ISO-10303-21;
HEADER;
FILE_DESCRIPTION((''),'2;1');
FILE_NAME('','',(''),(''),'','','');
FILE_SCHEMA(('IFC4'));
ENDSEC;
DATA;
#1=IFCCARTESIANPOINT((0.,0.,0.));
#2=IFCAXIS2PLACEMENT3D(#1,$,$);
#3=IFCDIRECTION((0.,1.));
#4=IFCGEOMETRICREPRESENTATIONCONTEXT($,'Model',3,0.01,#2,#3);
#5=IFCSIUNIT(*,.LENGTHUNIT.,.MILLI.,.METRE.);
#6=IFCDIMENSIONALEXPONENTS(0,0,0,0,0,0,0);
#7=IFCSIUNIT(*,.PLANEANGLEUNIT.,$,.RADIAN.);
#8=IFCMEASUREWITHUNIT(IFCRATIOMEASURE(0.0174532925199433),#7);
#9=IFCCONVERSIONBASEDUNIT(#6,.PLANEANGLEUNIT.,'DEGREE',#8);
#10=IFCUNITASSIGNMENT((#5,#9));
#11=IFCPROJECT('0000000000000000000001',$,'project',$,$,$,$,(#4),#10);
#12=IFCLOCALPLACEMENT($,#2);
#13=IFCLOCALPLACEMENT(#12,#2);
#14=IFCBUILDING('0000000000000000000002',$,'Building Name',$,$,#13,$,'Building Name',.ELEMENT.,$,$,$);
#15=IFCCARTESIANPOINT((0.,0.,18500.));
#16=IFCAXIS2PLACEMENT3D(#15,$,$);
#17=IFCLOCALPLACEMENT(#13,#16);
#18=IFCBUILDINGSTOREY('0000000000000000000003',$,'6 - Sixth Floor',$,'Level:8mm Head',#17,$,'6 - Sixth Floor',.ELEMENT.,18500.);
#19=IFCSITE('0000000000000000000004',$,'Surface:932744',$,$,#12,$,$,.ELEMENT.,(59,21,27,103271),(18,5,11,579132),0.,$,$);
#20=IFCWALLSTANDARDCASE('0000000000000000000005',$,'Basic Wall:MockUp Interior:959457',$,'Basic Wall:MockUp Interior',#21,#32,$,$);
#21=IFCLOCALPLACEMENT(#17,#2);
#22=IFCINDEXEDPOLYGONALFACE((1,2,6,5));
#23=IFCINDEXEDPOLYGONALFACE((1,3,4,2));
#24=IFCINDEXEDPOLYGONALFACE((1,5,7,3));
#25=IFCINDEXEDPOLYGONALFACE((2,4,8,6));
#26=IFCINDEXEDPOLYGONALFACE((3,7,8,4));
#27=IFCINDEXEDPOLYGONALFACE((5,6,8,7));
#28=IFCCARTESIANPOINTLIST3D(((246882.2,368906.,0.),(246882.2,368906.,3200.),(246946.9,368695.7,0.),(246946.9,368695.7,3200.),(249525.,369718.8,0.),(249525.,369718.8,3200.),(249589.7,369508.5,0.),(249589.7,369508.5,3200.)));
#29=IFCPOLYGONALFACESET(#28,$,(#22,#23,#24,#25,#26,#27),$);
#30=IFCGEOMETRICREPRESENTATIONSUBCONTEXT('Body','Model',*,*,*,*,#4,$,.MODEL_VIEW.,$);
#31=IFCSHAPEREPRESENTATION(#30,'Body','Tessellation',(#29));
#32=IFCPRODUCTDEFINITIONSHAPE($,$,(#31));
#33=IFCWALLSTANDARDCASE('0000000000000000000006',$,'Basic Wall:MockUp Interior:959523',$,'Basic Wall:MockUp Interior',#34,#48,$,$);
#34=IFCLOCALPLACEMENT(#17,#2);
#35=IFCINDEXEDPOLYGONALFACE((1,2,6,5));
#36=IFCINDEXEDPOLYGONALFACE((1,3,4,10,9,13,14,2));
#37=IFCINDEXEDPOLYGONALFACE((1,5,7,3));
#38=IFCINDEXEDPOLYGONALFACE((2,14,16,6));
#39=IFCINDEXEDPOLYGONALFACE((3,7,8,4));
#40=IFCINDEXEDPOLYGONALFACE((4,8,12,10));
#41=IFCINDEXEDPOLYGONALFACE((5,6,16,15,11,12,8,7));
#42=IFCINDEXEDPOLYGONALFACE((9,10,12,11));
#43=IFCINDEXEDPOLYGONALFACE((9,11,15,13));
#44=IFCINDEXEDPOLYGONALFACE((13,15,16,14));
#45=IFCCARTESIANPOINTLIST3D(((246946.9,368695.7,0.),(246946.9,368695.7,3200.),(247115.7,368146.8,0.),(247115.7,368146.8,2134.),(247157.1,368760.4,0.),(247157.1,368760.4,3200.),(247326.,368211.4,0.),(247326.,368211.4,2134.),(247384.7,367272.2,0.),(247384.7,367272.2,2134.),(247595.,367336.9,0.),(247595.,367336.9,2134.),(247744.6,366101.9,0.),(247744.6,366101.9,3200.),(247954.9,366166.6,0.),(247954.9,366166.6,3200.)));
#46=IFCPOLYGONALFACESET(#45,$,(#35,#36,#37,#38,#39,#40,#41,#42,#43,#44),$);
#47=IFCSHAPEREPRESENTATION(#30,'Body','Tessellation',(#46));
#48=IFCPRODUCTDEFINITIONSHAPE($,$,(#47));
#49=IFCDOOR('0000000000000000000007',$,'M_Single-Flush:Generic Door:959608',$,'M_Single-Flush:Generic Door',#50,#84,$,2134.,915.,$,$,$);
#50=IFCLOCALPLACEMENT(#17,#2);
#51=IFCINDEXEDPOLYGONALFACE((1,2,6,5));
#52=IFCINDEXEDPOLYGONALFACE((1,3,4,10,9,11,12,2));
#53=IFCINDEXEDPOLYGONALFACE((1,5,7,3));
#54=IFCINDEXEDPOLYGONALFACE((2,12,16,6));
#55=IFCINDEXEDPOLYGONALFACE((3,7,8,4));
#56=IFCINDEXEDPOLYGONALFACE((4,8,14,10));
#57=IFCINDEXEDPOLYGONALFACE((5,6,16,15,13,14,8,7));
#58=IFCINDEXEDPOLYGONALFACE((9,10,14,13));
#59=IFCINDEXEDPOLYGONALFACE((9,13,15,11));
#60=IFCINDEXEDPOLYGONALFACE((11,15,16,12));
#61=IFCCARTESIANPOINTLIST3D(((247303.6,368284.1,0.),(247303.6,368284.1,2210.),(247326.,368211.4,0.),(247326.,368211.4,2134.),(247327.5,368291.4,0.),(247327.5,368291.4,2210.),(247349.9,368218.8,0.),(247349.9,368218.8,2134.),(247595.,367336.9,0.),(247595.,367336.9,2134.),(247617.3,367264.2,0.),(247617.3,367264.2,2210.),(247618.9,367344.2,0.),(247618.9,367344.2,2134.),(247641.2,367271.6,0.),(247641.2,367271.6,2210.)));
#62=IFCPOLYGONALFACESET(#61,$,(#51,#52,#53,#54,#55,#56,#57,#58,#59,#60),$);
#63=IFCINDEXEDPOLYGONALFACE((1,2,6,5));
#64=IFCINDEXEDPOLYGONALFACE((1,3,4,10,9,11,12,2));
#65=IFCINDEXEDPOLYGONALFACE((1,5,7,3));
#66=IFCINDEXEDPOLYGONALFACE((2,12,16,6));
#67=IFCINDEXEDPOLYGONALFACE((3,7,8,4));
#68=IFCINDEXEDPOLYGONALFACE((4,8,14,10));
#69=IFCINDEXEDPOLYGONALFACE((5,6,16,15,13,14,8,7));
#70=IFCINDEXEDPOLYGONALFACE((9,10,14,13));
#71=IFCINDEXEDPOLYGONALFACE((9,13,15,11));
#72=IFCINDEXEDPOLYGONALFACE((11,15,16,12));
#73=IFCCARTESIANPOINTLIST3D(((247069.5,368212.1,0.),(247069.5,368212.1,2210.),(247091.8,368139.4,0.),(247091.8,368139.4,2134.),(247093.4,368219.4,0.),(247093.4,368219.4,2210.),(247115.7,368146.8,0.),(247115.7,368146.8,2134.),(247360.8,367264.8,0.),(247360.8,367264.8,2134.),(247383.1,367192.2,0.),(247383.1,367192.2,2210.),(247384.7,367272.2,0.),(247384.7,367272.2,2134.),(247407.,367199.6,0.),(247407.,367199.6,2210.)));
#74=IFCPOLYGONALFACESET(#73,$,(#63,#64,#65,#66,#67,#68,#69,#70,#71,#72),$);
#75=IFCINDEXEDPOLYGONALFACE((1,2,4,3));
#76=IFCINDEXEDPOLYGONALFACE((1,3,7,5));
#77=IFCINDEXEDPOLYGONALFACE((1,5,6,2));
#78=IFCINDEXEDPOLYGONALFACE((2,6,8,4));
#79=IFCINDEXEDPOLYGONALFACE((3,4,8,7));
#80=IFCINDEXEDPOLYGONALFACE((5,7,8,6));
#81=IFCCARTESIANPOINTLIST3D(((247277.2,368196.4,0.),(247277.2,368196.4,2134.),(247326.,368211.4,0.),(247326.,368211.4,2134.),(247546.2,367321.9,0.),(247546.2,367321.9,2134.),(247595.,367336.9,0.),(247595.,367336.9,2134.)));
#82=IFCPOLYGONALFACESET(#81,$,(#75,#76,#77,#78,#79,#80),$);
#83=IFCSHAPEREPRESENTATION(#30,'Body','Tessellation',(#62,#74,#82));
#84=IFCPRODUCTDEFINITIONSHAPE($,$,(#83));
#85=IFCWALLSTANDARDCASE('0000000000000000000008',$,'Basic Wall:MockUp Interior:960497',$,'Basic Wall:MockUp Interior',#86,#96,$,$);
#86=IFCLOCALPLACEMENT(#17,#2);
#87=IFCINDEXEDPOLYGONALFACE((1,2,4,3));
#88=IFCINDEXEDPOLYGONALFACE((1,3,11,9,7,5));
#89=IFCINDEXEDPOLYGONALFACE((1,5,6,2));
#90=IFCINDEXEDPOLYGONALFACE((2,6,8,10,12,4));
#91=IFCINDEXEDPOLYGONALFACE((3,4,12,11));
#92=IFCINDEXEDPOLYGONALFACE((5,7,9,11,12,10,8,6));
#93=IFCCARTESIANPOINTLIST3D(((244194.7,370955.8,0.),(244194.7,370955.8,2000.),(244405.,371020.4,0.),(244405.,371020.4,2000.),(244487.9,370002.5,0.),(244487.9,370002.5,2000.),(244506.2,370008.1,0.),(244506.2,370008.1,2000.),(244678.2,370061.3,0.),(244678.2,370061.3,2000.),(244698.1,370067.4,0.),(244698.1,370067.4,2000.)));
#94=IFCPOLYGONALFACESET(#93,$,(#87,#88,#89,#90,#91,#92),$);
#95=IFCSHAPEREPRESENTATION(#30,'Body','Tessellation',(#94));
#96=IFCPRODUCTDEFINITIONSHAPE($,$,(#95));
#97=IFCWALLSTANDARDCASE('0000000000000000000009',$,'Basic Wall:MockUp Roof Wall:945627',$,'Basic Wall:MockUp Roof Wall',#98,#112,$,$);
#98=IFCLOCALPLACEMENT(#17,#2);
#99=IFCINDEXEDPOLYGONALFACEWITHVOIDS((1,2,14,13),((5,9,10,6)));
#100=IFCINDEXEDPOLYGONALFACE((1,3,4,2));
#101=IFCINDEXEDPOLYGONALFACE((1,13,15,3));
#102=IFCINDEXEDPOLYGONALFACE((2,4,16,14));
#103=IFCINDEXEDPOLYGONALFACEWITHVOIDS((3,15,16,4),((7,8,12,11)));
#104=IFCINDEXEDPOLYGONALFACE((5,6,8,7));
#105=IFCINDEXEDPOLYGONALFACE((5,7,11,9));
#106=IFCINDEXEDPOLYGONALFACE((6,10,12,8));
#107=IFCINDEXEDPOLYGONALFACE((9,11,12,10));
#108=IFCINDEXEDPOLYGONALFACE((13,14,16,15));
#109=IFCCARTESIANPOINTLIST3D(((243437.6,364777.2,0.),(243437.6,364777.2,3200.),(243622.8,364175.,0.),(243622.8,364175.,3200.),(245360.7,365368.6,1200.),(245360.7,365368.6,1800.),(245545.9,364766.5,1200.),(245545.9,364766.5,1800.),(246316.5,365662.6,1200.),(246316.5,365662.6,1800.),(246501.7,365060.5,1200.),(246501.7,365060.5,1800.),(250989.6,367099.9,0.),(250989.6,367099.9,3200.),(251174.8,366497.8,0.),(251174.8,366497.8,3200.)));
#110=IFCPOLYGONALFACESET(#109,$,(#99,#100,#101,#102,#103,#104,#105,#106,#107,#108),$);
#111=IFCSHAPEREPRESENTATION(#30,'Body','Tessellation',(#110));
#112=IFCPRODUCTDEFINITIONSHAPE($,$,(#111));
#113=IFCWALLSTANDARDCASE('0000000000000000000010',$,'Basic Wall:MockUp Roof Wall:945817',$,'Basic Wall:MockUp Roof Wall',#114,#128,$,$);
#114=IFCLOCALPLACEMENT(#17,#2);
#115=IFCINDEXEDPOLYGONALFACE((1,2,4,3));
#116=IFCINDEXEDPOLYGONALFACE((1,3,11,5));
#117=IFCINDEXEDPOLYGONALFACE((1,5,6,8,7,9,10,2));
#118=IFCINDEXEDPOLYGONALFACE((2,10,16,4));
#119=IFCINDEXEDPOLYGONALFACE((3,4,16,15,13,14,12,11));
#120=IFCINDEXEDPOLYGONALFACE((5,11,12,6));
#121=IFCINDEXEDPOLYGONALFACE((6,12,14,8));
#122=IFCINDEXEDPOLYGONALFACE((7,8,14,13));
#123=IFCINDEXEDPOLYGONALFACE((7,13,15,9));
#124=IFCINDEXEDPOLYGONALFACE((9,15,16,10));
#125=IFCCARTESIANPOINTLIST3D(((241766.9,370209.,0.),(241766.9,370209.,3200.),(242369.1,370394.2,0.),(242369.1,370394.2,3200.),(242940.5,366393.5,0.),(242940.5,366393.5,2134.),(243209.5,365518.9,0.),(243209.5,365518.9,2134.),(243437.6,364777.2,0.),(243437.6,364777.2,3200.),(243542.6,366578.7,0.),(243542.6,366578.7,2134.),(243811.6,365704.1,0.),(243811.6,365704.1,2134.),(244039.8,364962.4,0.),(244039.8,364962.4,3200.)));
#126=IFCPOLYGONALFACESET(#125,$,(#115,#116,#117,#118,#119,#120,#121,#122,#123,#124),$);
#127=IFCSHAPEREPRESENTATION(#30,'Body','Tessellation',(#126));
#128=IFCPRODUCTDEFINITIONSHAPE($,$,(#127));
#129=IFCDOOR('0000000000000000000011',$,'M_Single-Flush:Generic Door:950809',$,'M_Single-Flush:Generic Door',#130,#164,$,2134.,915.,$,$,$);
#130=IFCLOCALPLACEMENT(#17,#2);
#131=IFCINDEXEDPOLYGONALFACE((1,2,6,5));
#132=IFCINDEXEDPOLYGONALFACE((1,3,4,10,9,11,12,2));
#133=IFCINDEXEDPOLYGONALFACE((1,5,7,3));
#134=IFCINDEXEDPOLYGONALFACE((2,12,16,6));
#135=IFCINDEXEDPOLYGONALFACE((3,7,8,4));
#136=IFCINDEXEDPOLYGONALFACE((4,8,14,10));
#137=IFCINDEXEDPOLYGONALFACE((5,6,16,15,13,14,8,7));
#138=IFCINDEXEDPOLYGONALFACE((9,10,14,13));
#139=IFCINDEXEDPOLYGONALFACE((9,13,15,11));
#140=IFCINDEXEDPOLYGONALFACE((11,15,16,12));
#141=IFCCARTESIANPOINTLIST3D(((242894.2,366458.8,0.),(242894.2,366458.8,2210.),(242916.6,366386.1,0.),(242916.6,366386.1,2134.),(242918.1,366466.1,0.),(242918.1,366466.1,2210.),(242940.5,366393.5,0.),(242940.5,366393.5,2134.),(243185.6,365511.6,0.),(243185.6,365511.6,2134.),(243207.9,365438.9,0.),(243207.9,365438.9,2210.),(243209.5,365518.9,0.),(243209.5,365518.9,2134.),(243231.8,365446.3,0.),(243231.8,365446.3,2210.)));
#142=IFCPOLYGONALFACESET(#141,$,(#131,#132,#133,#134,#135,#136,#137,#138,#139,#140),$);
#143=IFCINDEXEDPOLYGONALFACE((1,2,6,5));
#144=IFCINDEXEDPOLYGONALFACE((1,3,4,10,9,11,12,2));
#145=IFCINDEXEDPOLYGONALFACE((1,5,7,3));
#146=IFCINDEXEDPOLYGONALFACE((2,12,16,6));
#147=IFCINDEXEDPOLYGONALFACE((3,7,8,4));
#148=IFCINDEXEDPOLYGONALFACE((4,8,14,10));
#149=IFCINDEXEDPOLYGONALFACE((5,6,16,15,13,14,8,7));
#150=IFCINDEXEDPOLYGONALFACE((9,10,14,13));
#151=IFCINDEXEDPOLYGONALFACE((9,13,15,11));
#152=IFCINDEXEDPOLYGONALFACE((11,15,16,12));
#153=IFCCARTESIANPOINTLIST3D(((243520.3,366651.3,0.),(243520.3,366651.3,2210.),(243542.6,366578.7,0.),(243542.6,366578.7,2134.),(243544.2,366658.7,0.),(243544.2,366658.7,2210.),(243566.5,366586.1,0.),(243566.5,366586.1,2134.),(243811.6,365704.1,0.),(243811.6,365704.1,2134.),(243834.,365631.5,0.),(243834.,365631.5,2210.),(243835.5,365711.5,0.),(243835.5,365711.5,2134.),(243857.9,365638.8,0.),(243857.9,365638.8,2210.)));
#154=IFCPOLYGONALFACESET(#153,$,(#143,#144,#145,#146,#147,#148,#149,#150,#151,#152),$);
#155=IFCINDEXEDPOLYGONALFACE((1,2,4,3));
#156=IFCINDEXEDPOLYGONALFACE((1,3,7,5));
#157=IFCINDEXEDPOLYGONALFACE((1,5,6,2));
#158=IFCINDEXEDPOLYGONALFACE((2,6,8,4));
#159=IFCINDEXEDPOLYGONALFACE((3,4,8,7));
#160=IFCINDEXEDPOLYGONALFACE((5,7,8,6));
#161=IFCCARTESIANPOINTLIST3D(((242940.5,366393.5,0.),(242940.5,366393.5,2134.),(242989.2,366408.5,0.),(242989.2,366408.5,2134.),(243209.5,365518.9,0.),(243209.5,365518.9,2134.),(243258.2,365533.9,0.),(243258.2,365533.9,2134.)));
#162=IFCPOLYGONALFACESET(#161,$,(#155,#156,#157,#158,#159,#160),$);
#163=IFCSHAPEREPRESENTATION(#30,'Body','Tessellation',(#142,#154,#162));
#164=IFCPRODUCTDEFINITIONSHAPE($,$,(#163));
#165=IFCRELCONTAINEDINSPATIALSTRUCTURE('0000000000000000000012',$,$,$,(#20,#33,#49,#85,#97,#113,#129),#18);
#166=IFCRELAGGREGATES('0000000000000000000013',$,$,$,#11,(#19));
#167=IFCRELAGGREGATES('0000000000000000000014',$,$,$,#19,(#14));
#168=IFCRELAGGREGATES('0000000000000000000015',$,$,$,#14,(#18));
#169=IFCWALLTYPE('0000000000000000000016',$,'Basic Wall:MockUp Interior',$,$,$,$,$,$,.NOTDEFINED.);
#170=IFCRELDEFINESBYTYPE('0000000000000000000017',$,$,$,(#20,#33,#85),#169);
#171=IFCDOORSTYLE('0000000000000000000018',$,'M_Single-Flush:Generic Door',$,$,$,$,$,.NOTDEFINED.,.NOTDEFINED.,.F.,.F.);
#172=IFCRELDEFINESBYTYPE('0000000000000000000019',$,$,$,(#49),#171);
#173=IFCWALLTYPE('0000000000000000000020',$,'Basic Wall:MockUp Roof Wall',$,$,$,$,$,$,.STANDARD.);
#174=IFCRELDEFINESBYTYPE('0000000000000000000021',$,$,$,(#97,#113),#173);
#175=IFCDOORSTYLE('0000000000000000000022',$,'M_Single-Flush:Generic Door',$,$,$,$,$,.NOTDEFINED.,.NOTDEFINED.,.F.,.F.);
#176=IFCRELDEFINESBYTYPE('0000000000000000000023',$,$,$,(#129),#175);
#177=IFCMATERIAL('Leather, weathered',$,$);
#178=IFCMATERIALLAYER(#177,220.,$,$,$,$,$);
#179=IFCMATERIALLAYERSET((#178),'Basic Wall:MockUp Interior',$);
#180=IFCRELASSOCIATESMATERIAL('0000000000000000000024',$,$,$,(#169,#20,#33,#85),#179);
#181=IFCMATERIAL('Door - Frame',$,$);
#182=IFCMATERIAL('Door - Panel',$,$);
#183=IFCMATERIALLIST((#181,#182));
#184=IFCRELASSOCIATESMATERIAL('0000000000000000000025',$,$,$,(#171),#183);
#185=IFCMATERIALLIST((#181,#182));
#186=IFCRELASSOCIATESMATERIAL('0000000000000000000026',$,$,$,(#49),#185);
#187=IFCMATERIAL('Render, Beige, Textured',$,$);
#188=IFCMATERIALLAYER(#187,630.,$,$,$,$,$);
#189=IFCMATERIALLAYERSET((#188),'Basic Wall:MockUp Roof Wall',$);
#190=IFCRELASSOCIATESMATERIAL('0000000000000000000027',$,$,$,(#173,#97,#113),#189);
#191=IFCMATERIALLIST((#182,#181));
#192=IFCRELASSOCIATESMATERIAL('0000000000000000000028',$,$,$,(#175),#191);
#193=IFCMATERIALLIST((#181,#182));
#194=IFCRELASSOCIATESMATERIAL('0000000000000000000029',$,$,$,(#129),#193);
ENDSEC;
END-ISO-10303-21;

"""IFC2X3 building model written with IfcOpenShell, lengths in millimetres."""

from ifc_helpers import new_model, entity, si_unit, converted_unit, direction, frame, frame_2d, origin, place, context, subcontext, project, spatial, polyline, rectangle, outline, extrude, source, transform, mapped, material, material_list, layer, layer_set, layer_usage, type_object, type_shapes, element, fill, save


model = new_model("IFC2X3")

# Units and contexts
model_context = context("Model", 3, precision=0.01, world=origin(), true_north=direction((0.0, 1.0)))
body_context = subcontext(model_context, "Body", "Model", "MODEL_VIEW")
ifc_project = project(units=[si_unit("LENGTHUNIT", "METRE", prefix="MILLI"), converted_unit("PLANEANGLEUNIT", "DEGREE", entity("IfcRatioMeasure", 0.0174532925199433), si_unit("PLANEANGLEUNIT", "RADIAN"), dimensions=[0, 0, 0, 0, 0, 0, 0])], contexts=[model_context])

# Site, building, storey
site_placement = place(None, origin())
site = spatial("IfcSite", under=ifc_project, at=site_placement, Name="Surface:932744", CompositionType="ELEMENT", RefLatitude=(59, 21, 27, 103271), RefLongitude=(18, 5, 11, 579132), RefElevation=0.0)
building_placement = place(site_placement, origin())
building = spatial("IfcBuilding", under=site, at=building_placement, Name="Building Name", LongName="Building Name", CompositionType="ELEMENT")
storey_placement = place(building_placement, frame((0.0, 0.0, 18500.0)))
storey = spatial("IfcBuildingStorey", under=building, at=storey_placement, Name="6 - Sixth Floor", ObjectType="Level:8mm Head", LongName="6 - Sixth Floor", CompositionType="ELEMENT", Elevation=18500.0)

# Wall
ifc_material_1 = material(Name="Leather, weathered")
ifc_layer_1 = layer(ifc_material_1, 220.0)
ifc_layer_set_1 = layer_set([ifc_layer_1], Name="Basic Wall:MockUp Interior")
ifc_layer_usage_1 = layer_usage(ifc_layer_set_1, "AXIS2", "NEGATIVE", 110.0)
wall_type_1 = type_object("IfcWallType", Name="Basic Wall:MockUp Interior", PredefinedType="NOTDEFINED", material=ifc_layer_set_1)
wall_1_placement = place(storey_placement, frame((249557.4, 369613.6, 0.0), z_axis=(0.0, 0.0, 1.0), x_axis=(-0.955818, -0.293958, 0.0)))
element("IfcWallStandardCase", 1, at=wall_1_placement, inside=storey, type_object=wall_type_1, material=ifc_layer_usage_1, Name="Basic Wall:MockUp Interior:959457", ObjectType="Basic Wall:MockUp Interior", context=body_context, shape_type="SweptSolid", body=[
    extrude(rectangle(XDim=2765.0, YDim=220.0, at=frame_2d((1382.5, 0.0), x_axis=(-1.0, 0.0))), origin(), (0.0, 0.0, 1.0), 3200.0),
])

# Wall, opening, door
ifc_layer_usage_2 = layer_usage(ifc_layer_set_1, "AXIS2", "NEGATIVE", 110.0)
wall_2_placement = place(storey_placement, frame((247052.0, 368728.0, 0.0), z_axis=(0.0, 0.0, 1.0), x_axis=(0.29398, -0.955811, 0.0)))
wall_2 = element("IfcWallStandardCase", 2, at=wall_2_placement, inside=storey, type_object=wall_type_1, material=ifc_layer_usage_2, Name="Basic Wall:MockUp Interior:959523", ObjectType="Basic Wall:MockUp Interior", context=body_context, shape_type="SweptSolid", body=[
    extrude(rectangle(XDim=2713.7, YDim=220.0, at=frame_2d((1356.9, 0.0), x_axis=(-1.0, 0.0))), origin(), (0.0, 0.0, 1.0), 3200.0),
])
opening_1_placement = place(wall_2_placement, frame((574.3, -110.0, 0.0)))
opening_1 = element("IfcOpeningElement", 3, at=opening_1_placement, cuts=wall_2, ObjectType="Opening", context=body_context, shape_type="SweptSolid", body=[
    extrude(rectangle(XDim=915.0, YDim=2134.0, at=frame_2d((1067.0, 457.5), x_axis=(0.0, 1.0))), frame((0.0, 0.0, 0.0), z_axis=(0.0, 1.0, 0.0), x_axis=(0.0, 0.0, 1.0)), (0.0, 0.0, 1.0), 220.0),
])
ifc_material_2 = material(Name="Door - Frame")
ifc_material_3 = material(Name="Door - Panel")
ifc_material_list_1 = material_list([ifc_material_2, ifc_material_3])
ifc_material_list_2 = material_list([ifc_material_2, ifc_material_3])
door_style_1 = type_object("IfcDoorStyle", Name="M_Single-Flush:Generic Door", ConstructionType="NOTDEFINED", OperationType="NOTDEFINED", ParameterTakesPrecedence=False, Sizeable=False, material=ifc_material_list_2)
shared_shape_1 = source(origin(), body_context, "Body", "SweptSolid", [
    extrude(outline(polyline([(-533.5, -1124.0), (533.5, -1124.0), (533.5, 1086.0), (457.5, 1086.0), (457.5, -1048.0), (-457.5, -1048.0), (-457.5, 1086.0), (-533.5, 1086.0), (-533.5, -1124.0)])), frame((457.5, 220.0, 1086.0), z_axis=(0.0, 1.0, 0.0), x_axis=(1.0, 0.0, 0.0)), (0.0, 0.0, 1.0), 25.0),
    extrude(outline(polyline([(-1124.0, -533.5), (1086.0, -533.5), (1086.0, -457.5), (-1048.0, -457.5), (-1048.0, 457.5), (1086.0, 457.5), (1086.0, 533.5), (-1124.0, 533.5), (-1124.0, -533.5)])), frame((457.5, -25.0, 1086.0), z_axis=(0.0, 1.0, 0.0), x_axis=(0.0, 0.0, -1.0)), (0.0, 0.0, 1.0), 25.0),
    extrude(rectangle(XDim=51.0, YDim=915.0, at=frame_2d((0.0, 0.0), x_axis=(1.0, 0.0))), frame((457.5, 194.5, 0.0), z_axis=(0.0, 0.0, 1.0), x_axis=(0.0, 1.0, 0.0)), (0.0, 0.0, 1.0), 2134.0),
])
type_shapes(door_style_1, [shared_shape_1])
door_1_placement = place(opening_1_placement, origin())
door_1 = element("IfcDoor", 4, at=door_1_placement, inside=storey, type_object=door_style_1, material=ifc_material_list_1, Name="M_Single-Flush:Generic Door:959608", ObjectType="M_Single-Flush:Generic Door", OverallHeight=2134.0, OverallWidth=915.0, context=body_context, shape_type="MappedRepresentation", body=[
    mapped(shared_shape_1, transform((0.0, 0.0, 0.0), scale=1.0)),
])
fill(opening_1, door_1)

# Wall
ifc_layer_usage_3 = layer_usage(ifc_layer_set_1, "AXIS2", "NEGATIVE", 110.0)
wall_3_placement = place(storey_placement, frame((244593.1, 370034.8, 0.0), z_axis=(0.0, 0.0, 1.0), x_axis=(-0.29398, 0.955811, 0.0)))
element("IfcWallStandardCase", 5, at=wall_3_placement, inside=storey, type_object=wall_type_1, material=ifc_layer_usage_3, Name="Basic Wall:MockUp Interior:960497", ObjectType="Basic Wall:MockUp Interior", context=body_context, shape_type="SweptSolid", body=[
    extrude(outline(polyline([(997.3, -110.0), (997.3, 110.0), (0.0, 110.0), (0.0, 90.9), (0.2, -89.1), (0.3, -110.0), (997.3, -110.0)])), origin(), (0.0, 0.0, 1.0), 2000.0),
])

# Wall, opening
ifc_material_4 = material(Name="Render, Beige, Textured")
ifc_layer_2 = layer(ifc_material_4, 630.0)
ifc_layer_set_2 = layer_set([ifc_layer_2], Name="Basic Wall:MockUp Roof Wall")
ifc_layer_usage_4 = layer_usage(ifc_layer_set_2, "AXIS2", "NEGATIVE", 315.0)
wall_type_2 = type_object("IfcWallType", Name="Basic Wall:MockUp Roof Wall", PredefinedType="STANDARD", material=ifc_layer_set_2)
wall_4_placement = place(storey_placement, frame((251082.2, 366798.9, 0.0), z_axis=(0.0, 0.0, 1.0), x_axis=(-0.955811, -0.29398, 0.0)))
wall_4 = element("IfcWallStandardCase", 6, at=wall_4_placement, inside=storey, type_object=wall_type_2, material=ifc_layer_usage_4, Name="Basic Wall:MockUp Roof Wall:945627", ObjectType="Basic Wall:MockUp Roof Wall", context=body_context, shape_type="SweptSolid", body=[
    extrude(rectangle(XDim=7901.1, YDim=630.0, at=frame_2d((3950.6, 0.0), x_axis=(-1.0, 0.0))), origin(), (0.0, 0.0, 1.0), 3200.0),
])
opening_2_placement = place(wall_4_placement, frame((5889.2, 315.0, 1200.0)))
element("IfcOpeningElement", 7, at=opening_2_placement, cuts=wall_4, ObjectType="Opening", context=body_context, shape_type="SweptSolid", body=[
    extrude(rectangle(XDim=600.0, YDim=1000.0, at=frame_2d((300.0, 500.0), x_axis=(1.0, 0.0))), frame((0.0, 0.0, 0.0), z_axis=(0.0, -1.0, 0.0), x_axis=(0.0, 0.0, 1.0)), (0.0, 0.0, 1.0), 630.0),
])

# Wall, opening, door
ifc_layer_usage_5 = layer_usage(ifc_layer_set_2, "AXIS2", "NEGATIVE", 315.0)
wall_5_placement = place(storey_placement, frame((242068.0, 370301.6, 0.0), z_axis=(0.0, 0.0, 1.0), x_axis=(0.29398, -0.955811, 0.0)))
wall_5 = element("IfcWallStandardCase", 8, at=wall_5_placement, inside=storey, type_object=wall_type_2, material=ifc_layer_usage_5, Name="Basic Wall:MockUp Roof Wall:945817", ObjectType="Basic Wall:MockUp Roof Wall", context=body_context, shape_type="SweptSolid", body=[
    extrude(rectangle(XDim=5683.0, YDim=630.0, at=frame_2d((2841.5, 0.0), x_axis=(-1.0, 0.0))), origin(), (0.0, 0.0, 1.0), 3200.0),
])
opening_3_placement = place(wall_5_placement, frame((4906.9, 315.0, 0.0)))
opening_3 = element("IfcOpeningElement", 9, at=opening_3_placement, cuts=wall_5, ObjectType="Opening", context=body_context, shape_type="SweptSolid", body=[
    extrude(rectangle(XDim=915.0, YDim=2134.0, at=frame_2d((1067.0, 457.5), x_axis=(0.0, -1.0))), frame((0.0, 0.0, 0.0), z_axis=(0.0, -1.0, 0.0), x_axis=(0.0, 0.0, 1.0)), (0.0, 0.0, 1.0), 630.0),
])
ifc_material_list_3 = material_list([ifc_material_2, ifc_material_3])
ifc_material_list_4 = material_list([ifc_material_3, ifc_material_2])
door_style_2 = type_object("IfcDoorStyle", Name="M_Single-Flush:Generic Door", ConstructionType="NOTDEFINED", OperationType="NOTDEFINED", ParameterTakesPrecedence=False, Sizeable=False, material=ifc_material_list_4)
shared_shape_2 = source(origin(), body_context, "Body", "SweptSolid", [
    extrude(outline(polyline([(-533.5, -1124.0), (533.5, -1124.0), (533.5, 1086.0), (457.5, 1086.0), (457.5, -1048.0), (-457.5, -1048.0), (-457.5, 1086.0), (-533.5, 1086.0), (-533.5, -1124.0)])), frame((457.5, 655.0, 1086.0), z_axis=(0.0, -1.0, 0.0), x_axis=(-1.0, 0.0, 0.0)), (0.0, 0.0, 1.0), 25.0),
    extrude(outline(polyline([(-1124.0, -533.5), (1086.0, -533.5), (1086.0, -457.5), (-1048.0, -457.5), (-1048.0, 457.5), (1086.0, 457.5), (1086.0, 533.5), (-1124.0, 533.5), (-1124.0, -533.5)])), frame((457.5, 0.0, 1086.0), z_axis=(0.0, -1.0, 0.0), x_axis=(0.0, 0.0, -1.0)), (0.0, 0.0, 1.0), 25.0),
    extrude(rectangle(XDim=915.0, YDim=51.0, at=frame_2d((0.0, 0.0), x_axis=(1.0, 0.0))), frame((457.5, 604.5, 0.0)), (0.0, 0.0, 1.0), 2134.0),
])
type_shapes(door_style_2, [shared_shape_2])
door_2_placement = place(opening_3_placement, frame((0.0, 0.0, 0.0), z_axis=(0.0, 0.0, 1.0), x_axis=(-1.0, 0.0, 0.0)))
door_2 = element("IfcDoor", 10, at=door_2_placement, inside=storey, type_object=door_style_2, material=ifc_material_list_3, Name="M_Single-Flush:Generic Door:950809", ObjectType="M_Single-Flush:Generic Door", OverallHeight=2134.0, OverallWidth=915.0, context=body_context, shape_type="MappedRepresentation", body=[
    mapped(shared_shape_2, transform((0.0, 0.0, 0.0), scale=1.0)),
])
fill(opening_3, door_2)

save(model, "model.ifc")
